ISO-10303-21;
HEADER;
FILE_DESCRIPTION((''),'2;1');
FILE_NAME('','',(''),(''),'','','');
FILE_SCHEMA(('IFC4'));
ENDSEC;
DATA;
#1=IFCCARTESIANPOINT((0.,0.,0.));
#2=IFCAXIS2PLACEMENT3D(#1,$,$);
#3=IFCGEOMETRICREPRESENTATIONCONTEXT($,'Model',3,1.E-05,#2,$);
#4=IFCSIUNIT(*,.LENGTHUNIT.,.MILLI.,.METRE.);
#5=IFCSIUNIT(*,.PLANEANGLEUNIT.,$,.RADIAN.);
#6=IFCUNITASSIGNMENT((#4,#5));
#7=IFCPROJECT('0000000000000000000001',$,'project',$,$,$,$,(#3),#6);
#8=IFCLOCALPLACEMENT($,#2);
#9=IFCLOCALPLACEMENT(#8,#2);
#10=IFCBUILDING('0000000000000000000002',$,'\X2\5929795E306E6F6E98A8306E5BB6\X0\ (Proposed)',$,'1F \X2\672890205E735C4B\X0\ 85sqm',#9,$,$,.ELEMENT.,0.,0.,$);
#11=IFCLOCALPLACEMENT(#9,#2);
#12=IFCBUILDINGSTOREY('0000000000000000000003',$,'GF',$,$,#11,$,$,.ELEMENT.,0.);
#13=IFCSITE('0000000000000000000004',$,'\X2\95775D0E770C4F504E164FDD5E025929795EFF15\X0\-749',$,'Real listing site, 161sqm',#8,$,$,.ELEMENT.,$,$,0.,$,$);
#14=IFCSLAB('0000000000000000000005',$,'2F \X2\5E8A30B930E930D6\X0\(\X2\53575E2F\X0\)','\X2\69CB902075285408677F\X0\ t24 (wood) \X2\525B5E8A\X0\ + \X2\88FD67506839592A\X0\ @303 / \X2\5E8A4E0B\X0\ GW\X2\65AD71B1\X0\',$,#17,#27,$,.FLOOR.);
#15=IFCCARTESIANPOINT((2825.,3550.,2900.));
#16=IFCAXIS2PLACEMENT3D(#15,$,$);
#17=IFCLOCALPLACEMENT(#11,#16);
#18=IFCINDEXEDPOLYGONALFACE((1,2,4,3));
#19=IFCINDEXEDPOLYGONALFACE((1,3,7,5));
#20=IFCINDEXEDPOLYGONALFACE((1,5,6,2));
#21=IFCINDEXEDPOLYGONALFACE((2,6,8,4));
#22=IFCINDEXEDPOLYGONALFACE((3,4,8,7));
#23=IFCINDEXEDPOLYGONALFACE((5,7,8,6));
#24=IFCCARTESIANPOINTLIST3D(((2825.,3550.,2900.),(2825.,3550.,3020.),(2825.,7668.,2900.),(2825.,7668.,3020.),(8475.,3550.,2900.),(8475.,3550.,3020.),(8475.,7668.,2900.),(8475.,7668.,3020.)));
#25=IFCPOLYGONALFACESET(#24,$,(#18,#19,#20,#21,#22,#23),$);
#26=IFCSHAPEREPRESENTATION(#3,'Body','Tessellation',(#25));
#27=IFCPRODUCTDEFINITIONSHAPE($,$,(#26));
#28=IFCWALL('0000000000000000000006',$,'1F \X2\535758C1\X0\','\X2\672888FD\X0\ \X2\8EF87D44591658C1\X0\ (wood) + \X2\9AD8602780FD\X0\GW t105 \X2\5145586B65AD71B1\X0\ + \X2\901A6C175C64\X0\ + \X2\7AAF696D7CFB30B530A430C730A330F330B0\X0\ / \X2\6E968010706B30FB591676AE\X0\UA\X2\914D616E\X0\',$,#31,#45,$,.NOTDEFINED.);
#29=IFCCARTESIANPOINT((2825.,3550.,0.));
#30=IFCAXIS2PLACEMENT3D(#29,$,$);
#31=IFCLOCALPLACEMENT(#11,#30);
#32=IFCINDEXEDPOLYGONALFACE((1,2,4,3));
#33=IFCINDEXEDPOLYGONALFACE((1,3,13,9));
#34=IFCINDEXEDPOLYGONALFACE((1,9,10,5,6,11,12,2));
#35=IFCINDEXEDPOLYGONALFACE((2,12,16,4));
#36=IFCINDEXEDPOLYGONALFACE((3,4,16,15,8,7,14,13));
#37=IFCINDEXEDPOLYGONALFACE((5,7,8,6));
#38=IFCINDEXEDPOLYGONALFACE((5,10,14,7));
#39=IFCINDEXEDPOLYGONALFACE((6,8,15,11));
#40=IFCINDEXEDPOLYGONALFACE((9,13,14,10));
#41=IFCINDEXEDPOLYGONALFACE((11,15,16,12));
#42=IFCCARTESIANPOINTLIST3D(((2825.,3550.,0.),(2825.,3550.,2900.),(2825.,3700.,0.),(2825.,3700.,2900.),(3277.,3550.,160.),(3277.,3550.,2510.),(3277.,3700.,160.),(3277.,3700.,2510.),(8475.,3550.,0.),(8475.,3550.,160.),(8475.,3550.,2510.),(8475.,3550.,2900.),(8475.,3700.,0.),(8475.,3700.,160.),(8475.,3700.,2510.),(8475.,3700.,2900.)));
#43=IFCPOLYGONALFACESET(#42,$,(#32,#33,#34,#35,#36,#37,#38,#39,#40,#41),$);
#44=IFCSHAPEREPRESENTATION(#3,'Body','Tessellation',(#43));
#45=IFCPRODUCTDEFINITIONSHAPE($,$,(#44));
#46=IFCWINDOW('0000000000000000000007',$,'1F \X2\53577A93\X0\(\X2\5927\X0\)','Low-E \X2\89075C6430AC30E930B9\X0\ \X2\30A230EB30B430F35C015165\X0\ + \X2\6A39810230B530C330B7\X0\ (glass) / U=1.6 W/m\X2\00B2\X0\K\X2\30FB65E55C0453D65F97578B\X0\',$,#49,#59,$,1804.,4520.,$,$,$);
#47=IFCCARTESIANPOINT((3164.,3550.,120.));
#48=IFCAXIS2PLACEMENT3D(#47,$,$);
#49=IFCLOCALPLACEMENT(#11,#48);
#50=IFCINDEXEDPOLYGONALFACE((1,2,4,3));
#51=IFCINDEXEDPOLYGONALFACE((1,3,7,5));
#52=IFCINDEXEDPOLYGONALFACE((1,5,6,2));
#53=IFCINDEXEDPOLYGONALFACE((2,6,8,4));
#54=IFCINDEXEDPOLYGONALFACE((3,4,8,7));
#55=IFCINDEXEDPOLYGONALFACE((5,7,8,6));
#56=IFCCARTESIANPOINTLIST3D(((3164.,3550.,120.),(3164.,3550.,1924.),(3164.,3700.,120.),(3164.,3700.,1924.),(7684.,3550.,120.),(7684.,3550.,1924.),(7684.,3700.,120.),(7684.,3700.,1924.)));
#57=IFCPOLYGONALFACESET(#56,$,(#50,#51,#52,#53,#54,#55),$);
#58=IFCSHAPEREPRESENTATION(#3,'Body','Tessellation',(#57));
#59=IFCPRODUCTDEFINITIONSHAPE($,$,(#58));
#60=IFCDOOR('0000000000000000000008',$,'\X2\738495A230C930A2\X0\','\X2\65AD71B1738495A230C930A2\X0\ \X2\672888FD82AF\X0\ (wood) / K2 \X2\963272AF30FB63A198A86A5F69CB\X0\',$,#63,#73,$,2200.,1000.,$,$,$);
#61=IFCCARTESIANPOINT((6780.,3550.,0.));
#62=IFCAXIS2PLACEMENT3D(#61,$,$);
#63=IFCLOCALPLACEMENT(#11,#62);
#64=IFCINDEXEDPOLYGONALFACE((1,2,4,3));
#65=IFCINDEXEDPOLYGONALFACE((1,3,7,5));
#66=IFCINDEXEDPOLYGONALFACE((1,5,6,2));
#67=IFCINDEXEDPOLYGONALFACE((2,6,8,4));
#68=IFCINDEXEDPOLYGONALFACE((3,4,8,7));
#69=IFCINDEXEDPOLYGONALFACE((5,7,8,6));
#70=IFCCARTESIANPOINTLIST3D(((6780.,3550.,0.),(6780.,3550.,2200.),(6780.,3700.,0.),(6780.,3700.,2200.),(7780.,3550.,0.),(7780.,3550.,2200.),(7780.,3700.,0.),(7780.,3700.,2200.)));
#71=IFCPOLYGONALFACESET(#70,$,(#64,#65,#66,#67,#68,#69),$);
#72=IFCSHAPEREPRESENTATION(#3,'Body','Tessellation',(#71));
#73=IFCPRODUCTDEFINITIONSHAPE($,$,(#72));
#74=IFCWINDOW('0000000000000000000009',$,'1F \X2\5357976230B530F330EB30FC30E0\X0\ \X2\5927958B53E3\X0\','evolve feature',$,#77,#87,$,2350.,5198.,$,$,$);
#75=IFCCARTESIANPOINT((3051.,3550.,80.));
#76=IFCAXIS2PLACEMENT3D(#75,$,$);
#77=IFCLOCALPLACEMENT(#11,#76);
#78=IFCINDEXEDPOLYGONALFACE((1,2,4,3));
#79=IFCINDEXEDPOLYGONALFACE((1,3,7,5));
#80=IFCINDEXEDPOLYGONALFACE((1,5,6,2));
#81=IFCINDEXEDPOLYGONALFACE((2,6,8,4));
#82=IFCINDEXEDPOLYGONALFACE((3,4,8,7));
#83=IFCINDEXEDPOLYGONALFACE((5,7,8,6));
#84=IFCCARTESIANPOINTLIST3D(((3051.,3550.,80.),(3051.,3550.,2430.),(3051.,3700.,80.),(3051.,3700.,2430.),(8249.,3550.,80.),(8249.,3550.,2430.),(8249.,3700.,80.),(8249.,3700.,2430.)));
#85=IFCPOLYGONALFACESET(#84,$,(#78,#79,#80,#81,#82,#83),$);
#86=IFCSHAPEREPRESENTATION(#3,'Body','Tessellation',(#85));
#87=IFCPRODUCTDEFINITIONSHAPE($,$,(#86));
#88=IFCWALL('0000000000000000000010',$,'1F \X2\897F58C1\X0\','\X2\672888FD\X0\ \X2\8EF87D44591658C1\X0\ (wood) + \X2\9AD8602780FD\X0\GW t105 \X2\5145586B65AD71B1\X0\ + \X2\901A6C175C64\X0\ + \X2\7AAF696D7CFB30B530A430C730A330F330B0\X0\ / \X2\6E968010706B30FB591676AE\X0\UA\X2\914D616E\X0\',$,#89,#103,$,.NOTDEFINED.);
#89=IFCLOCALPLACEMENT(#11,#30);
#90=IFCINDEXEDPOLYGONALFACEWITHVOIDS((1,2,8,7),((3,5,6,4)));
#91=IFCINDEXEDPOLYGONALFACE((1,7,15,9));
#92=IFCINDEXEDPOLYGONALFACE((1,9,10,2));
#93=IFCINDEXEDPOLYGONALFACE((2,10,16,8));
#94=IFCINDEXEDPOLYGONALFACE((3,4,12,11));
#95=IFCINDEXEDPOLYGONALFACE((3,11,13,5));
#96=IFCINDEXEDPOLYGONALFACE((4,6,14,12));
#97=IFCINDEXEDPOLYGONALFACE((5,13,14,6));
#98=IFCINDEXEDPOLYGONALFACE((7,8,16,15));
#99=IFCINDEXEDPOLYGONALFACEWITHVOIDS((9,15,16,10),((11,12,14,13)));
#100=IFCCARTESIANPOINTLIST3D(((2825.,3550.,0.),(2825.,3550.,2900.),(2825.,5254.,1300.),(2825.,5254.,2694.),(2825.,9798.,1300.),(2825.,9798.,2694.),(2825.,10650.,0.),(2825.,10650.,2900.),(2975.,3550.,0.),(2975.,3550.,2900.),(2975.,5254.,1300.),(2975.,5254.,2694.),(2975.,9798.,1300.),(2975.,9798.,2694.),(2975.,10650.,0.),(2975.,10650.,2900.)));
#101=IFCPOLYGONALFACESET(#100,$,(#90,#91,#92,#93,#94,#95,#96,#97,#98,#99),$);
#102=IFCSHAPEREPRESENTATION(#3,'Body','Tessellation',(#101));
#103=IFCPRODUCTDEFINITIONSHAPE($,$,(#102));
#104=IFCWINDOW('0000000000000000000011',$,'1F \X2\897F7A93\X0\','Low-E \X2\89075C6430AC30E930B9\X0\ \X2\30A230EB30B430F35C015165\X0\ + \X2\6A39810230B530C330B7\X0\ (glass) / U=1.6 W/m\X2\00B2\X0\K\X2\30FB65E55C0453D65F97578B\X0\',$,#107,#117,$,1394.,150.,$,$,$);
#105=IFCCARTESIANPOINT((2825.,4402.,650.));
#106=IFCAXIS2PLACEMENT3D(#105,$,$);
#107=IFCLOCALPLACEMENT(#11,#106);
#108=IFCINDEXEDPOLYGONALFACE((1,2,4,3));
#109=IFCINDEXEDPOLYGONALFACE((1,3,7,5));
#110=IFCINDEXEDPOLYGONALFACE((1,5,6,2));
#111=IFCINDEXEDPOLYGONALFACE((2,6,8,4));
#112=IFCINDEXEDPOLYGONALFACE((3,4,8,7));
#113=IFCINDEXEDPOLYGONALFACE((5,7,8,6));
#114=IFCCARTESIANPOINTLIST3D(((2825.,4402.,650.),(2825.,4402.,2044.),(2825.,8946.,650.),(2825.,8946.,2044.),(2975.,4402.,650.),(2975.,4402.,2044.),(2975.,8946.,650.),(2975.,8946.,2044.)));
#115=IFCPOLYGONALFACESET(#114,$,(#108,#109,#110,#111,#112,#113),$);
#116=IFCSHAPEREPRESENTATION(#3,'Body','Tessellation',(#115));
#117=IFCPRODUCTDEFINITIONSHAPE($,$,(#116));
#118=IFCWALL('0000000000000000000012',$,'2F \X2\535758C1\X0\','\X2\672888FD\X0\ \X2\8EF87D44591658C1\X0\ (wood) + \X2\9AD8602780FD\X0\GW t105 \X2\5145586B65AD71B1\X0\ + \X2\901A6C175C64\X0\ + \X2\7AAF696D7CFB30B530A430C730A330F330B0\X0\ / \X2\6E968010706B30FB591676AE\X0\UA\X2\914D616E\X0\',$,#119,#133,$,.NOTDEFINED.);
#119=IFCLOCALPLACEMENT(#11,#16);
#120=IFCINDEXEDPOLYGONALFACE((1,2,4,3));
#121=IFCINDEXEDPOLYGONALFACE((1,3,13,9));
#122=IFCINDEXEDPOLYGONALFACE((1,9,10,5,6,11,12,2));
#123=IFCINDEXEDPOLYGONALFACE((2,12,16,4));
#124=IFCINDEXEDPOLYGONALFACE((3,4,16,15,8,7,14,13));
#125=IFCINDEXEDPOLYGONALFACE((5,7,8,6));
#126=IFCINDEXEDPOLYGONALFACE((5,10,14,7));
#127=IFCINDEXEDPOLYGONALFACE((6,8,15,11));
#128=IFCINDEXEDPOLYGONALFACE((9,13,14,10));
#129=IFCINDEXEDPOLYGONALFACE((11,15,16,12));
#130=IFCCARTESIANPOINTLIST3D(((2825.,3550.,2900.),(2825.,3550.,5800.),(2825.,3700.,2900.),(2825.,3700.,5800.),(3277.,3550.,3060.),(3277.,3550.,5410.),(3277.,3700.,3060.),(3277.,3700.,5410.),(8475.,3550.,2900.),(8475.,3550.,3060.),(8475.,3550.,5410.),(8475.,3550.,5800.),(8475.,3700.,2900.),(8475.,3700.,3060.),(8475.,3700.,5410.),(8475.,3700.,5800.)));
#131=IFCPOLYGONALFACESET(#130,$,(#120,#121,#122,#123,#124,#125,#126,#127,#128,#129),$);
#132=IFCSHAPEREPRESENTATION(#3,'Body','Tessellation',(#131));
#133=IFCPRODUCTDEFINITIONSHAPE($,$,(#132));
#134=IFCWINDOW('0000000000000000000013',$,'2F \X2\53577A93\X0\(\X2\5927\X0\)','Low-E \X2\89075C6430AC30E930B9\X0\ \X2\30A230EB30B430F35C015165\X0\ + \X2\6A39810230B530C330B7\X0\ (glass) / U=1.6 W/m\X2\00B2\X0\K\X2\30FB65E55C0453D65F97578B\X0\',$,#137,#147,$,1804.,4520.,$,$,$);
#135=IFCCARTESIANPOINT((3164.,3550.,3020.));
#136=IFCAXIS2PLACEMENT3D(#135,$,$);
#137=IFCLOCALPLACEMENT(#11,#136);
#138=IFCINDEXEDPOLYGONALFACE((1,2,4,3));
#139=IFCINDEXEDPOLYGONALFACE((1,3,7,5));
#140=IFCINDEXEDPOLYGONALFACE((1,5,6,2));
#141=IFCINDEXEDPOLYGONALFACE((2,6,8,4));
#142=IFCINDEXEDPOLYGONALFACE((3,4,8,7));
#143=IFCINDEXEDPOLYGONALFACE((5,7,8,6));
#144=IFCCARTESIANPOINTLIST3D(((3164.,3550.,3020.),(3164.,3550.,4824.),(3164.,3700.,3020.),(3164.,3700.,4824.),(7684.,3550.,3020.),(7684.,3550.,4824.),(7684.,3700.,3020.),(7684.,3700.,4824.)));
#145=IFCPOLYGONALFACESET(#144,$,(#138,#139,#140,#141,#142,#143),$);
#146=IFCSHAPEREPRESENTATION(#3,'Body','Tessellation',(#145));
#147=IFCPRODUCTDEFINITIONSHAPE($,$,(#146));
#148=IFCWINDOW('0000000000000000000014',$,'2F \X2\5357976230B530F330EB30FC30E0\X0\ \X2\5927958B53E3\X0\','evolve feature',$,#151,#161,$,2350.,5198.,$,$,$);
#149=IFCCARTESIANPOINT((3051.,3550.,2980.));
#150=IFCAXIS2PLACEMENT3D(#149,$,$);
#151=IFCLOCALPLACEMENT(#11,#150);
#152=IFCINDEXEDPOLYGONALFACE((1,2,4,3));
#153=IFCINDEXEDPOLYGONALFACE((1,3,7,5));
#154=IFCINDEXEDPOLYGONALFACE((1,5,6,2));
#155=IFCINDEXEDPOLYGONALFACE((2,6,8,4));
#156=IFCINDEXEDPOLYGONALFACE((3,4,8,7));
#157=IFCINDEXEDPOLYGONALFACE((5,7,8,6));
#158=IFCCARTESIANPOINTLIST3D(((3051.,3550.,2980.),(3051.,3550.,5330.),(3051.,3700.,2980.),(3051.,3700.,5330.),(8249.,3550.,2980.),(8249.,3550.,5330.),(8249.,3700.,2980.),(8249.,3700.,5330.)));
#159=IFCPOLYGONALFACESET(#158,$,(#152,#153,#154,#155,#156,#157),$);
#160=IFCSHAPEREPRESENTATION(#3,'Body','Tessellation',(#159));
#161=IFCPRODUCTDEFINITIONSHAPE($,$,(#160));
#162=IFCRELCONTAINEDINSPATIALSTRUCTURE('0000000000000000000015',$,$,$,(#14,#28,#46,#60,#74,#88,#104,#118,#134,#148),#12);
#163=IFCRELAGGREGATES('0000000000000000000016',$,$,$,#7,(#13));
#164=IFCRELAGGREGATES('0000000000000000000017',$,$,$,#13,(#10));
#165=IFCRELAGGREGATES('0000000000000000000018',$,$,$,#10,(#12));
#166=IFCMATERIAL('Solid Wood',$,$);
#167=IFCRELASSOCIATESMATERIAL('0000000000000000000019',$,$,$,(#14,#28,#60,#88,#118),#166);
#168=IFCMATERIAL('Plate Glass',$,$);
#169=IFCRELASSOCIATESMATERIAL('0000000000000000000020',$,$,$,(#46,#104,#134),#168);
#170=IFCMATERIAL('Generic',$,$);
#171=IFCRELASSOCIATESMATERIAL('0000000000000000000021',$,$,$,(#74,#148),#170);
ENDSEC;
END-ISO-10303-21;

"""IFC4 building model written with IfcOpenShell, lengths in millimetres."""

from ifc_helpers import new_model, si_unit, frame, frame_2d, origin, place, context, project, spatial, rectangle, extrude, material, element, fill, save


model = new_model("IFC4")

# Units and contexts
model_context = context("Model", 3, precision=1e-05, world=origin())
ifc_project = project(units=[si_unit("LENGTHUNIT", "METRE", prefix="MILLI"), si_unit("PLANEANGLEUNIT", "RADIAN")], contexts=[model_context])

# Site, building, storey
site_placement = place(None, origin())
site = spatial("IfcSite", under=ifc_project, at=site_placement, Name="長崎県佐世保市天神５-749", ObjectType="Real listing site, 161sqm", CompositionType="ELEMENT", RefElevation=0.0)
building_placement = place(site_placement, origin())
building = spatial("IfcBuilding", under=site, at=building_placement, Name="天神の潮風の家 (Proposed)", ObjectType="1F 木造平屋 85sqm", CompositionType="ELEMENT", ElevationOfRefHeight=0.0, ElevationOfTerrain=0.0)
storey_placement = place(building_placement, origin())
storey = spatial("IfcBuildingStorey", under=building, at=storey_placement, Name="GF", CompositionType="ELEMENT", Elevation=0.0)

# Slab
ifc_material_1 = material(Name="Solid Wood")
slab_1_placement = place(storey_placement, frame((2825.0, 3550.0, 2900.0)))
element("IfcSlab", 1, at=slab_1_placement, inside=storey, material=ifc_material_1, Name="2F 床スラブ(南帯)", Description="構造用合板 t24 (wood) 剛床 + 製材根太 @303 / 床下 GW断熱", PredefinedType="FLOOR", context=model_context, shape_type="SweptSolid", body=[
    extrude(rectangle(XDim=5650.0, YDim=4118.0, at=frame_2d((2825.0, 2059.0))), frame((2825.0, 3550.0, 2900.0)), (0.0, 0.0, 1.0), 120.0),
])
ifc_material_2 = material(Name="Generic")

# Wall, openings, windows, door
wall_1_placement = place(storey_placement, frame((2825.0, 3550.0, 0.0)))
wall_1 = element("IfcWall", 2, at=wall_1_placement, inside=storey, material=ifc_material_1, Name="1F 南壁", Description="木製 軸組外壁 (wood) + 高性能GW t105 充填断熱 + 通気層 + 窯業系サイディング / 準耐火・外皮UA配慮", PredefinedType="NOTDEFINED", context=model_context, shape_type="SweptSolid", body=[
    extrude(rectangle(XDim=5650.0, YDim=150.0, at=frame_2d((2825.0, 75.0))), frame((2825.0, 3550.0, 0.0)), (0.0, 0.0, 1.0), 2900.0),
])
opening_1_placement = place(storey_placement, frame((3164.0, 3550.0, 120.0)))
opening_1 = element("IfcOpeningElement", 3, at=opening_1_placement, cuts=wall_1, PredefinedType="NOTDEFINED", context=model_context, shape_type="SweptSolid", body=[
    extrude(rectangle(XDim=4520.0, YDim=150.0, at=frame_2d((2260.0, 75.0))), frame((3164.0, 3550.0, 120.0)), (0.0, 0.0, 1.0), 1804.0),
])
opening_2_placement = place(storey_placement, frame((6780.0, 3550.0, 0.0)))
opening_2 = element("IfcOpeningElement", 4, at=opening_2_placement, cuts=wall_1, PredefinedType="NOTDEFINED", context=model_context, shape_type="SweptSolid", body=[
    extrude(rectangle(XDim=1000.0, YDim=150.0, at=frame_2d((500.0, 75.0))), frame((6780.0, 3550.0, 0.0)), (0.0, 0.0, 1.0), 2200.0),
])
opening_3_placement = place(storey_placement, frame((3051.0, 3550.0, 80.0)))
opening_3 = element("IfcOpeningElement", 5, at=opening_3_placement, cuts=wall_1, PredefinedType="NOTDEFINED", context=model_context, shape_type="SweptSolid", body=[
    extrude(rectangle(XDim=5198.0, YDim=150.0, at=frame_2d((2599.0, 75.0))), frame((3051.0, 3550.0, 80.0)), (0.0, 0.0, 1.0), 2350.0),
])
ifc_material_3 = material(Name="Plate Glass")
window_1_placement = place(storey_placement, frame((3164.0, 3550.0, 120.0)))
window_1 = element("IfcWindow", 6, at=window_1_placement, inside=storey, material=ifc_material_3, Name="1F 南窓(大)", Description="Low-E 複層ガラス アルゴン封入 + 樹脂サッシ (glass) / U=1.6 W/m²K・日射取得型", OverallHeight=1804.0, OverallWidth=4520.0, context=model_context, shape_type="SweptSolid", body=[
    extrude(rectangle(XDim=4520.0, YDim=150.0, at=frame_2d((2260.0, 75.0))), frame((3164.0, 3550.0, 120.0)), (0.0, 0.0, 1.0), 1804.0),
])
fill(opening_1, window_1)
door_placement = place(storey_placement, frame((6780.0, 3550.0, 0.0)))
door = element("IfcDoor", 7, at=door_placement, inside=storey, material=ifc_material_1, Name="玄関ドア", Description="断熱玄関ドア 木製芯 (wood) / K2 防犯・採風機構", OverallHeight=2200.0, OverallWidth=1000.0, context=model_context, shape_type="SweptSolid", body=[
    extrude(rectangle(XDim=1000.0, YDim=150.0, at=frame_2d((500.0, 75.0))), frame((6780.0, 3550.0, 0.0)), (0.0, 0.0, 1.0), 2200.0),
])
fill(opening_2, door)
window_2_placement = place(storey_placement, frame((3051.0, 3550.0, 80.0)))
window_2 = element("IfcWindow", 8, at=window_2_placement, inside=storey, material=ifc_material_2, Name="1F 南面サンルーム 大開口", Description="evolve feature", OverallHeight=2350.0, OverallWidth=5198.0, context=model_context, shape_type="SweptSolid", body=[
    extrude(rectangle(XDim=5198.0, YDim=150.0, at=frame_2d((2599.0, 75.0))), frame((3051.0, 3550.0, 80.0)), (0.0, 0.0, 1.0), 2350.0),
])
fill(opening_3, window_2)

# Wall, opening, window
wall_2_placement = place(storey_placement, frame((2825.0, 3550.0, 0.0)))
wall_2 = element("IfcWall", 9, at=wall_2_placement, inside=storey, material=ifc_material_1, Name="1F 西壁", Description="木製 軸組外壁 (wood) + 高性能GW t105 充填断熱 + 通気層 + 窯業系サイディング / 準耐火・外皮UA配慮", PredefinedType="NOTDEFINED", context=model_context, shape_type="SweptSolid", body=[
    extrude(rectangle(XDim=150.0, YDim=7100.0, at=frame_2d((75.0, 3550.0))), frame((2825.0, 3550.0, 0.0)), (0.0, 0.0, 1.0), 2900.0),
])
opening_4_placement = place(storey_placement, frame((2825.0, 4402.0, 650.0)))
opening_4 = element("IfcOpeningElement", 10, at=opening_4_placement, cuts=wall_2, PredefinedType="NOTDEFINED", context=model_context, shape_type="SweptSolid", body=[
    extrude(rectangle(XDim=150.0, YDim=4544.0, at=frame_2d((75.0, 2272.0))), frame((2825.0, 4402.0, 650.0)), (0.0, 0.0, 1.0), 1394.0),
])
window_3_placement = place(storey_placement, frame((2825.0, 4402.0, 650.0)))
window_3 = element("IfcWindow", 11, at=window_3_placement, inside=storey, material=ifc_material_3, Name="1F 西窓", Description="Low-E 複層ガラス アルゴン封入 + 樹脂サッシ (glass) / U=1.6 W/m²K・日射取得型", OverallHeight=1394.0, OverallWidth=150.0, context=model_context, shape_type="SweptSolid", body=[
    extrude(rectangle(XDim=150.0, YDim=4544.0, at=frame_2d((75.0, 2272.0))), frame((2825.0, 4402.0, 650.0)), (0.0, 0.0, 1.0), 1394.0),
])
fill(opening_4, window_3)

# Wall, openings, windows
wall_3_placement = place(storey_placement, frame((2825.0, 3550.0, 2900.0)))
wall_3 = element("IfcWall", 12, at=wall_3_placement, inside=storey, material=ifc_material_1, Name="2F 南壁", Description="木製 軸組外壁 (wood) + 高性能GW t105 充填断熱 + 通気層 + 窯業系サイディング / 準耐火・外皮UA配慮", PredefinedType="NOTDEFINED", context=model_context, shape_type="SweptSolid", body=[
    extrude(rectangle(XDim=5650.0, YDim=150.0, at=frame_2d((2825.0, 75.0))), frame((2825.0, 3550.0, 2900.0)), (0.0, 0.0, 1.0), 2900.0),
])
opening_5_placement = place(storey_placement, frame((3164.0, 3550.0, 3020.0)))
opening_5 = element("IfcOpeningElement", 13, at=opening_5_placement, cuts=wall_3, PredefinedType="NOTDEFINED", context=model_context, shape_type="SweptSolid", body=[
    extrude(rectangle(XDim=4520.0, YDim=150.0, at=frame_2d((2260.0, 75.0))), frame((3164.0, 3550.0, 3020.0)), (0.0, 0.0, 1.0), 1804.0),
])
opening_6_placement = place(storey_placement, frame((3051.0, 3550.0, 2980.0)))
opening_6 = element("IfcOpeningElement", 14, at=opening_6_placement, cuts=wall_3, PredefinedType="NOTDEFINED", context=model_context, shape_type="SweptSolid", body=[
    extrude(rectangle(XDim=5198.0, YDim=150.0, at=frame_2d((2599.0, 75.0))), frame((3051.0, 3550.0, 2980.0)), (0.0, 0.0, 1.0), 2350.0),
])
window_4_placement = place(storey_placement, frame((3164.0, 3550.0, 3020.0)))
window_4 = element("IfcWindow", 15, at=window_4_placement, inside=storey, material=ifc_material_3, Name="2F 南窓(大)", Description="Low-E 複層ガラス アルゴン封入 + 樹脂サッシ (glass) / U=1.6 W/m²K・日射取得型", OverallHeight=1804.0, OverallWidth=4520.0, context=model_context, shape_type="SweptSolid", body=[
    extrude(rectangle(XDim=4520.0, YDim=150.0, at=frame_2d((2260.0, 75.0))), frame((3164.0, 3550.0, 3020.0)), (0.0, 0.0, 1.0), 1804.0),
])
fill(opening_5, window_4)
window_5_placement = place(storey_placement, frame((3051.0, 3550.0, 2980.0)))
window_5 = element("IfcWindow", 16, at=window_5_placement, inside=storey, material=ifc_material_2, Name="2F 南面サンルーム 大開口", Description="evolve feature", OverallHeight=2350.0, OverallWidth=5198.0, context=model_context, shape_type="SweptSolid", body=[
    extrude(rectangle(XDim=5198.0, YDim=150.0, at=frame_2d((2599.0, 75.0))), frame((3051.0, 3550.0, 2980.0)), (0.0, 0.0, 1.0), 2350.0),
])
fill(opening_6, window_5)

save(model, "model.ifc")
